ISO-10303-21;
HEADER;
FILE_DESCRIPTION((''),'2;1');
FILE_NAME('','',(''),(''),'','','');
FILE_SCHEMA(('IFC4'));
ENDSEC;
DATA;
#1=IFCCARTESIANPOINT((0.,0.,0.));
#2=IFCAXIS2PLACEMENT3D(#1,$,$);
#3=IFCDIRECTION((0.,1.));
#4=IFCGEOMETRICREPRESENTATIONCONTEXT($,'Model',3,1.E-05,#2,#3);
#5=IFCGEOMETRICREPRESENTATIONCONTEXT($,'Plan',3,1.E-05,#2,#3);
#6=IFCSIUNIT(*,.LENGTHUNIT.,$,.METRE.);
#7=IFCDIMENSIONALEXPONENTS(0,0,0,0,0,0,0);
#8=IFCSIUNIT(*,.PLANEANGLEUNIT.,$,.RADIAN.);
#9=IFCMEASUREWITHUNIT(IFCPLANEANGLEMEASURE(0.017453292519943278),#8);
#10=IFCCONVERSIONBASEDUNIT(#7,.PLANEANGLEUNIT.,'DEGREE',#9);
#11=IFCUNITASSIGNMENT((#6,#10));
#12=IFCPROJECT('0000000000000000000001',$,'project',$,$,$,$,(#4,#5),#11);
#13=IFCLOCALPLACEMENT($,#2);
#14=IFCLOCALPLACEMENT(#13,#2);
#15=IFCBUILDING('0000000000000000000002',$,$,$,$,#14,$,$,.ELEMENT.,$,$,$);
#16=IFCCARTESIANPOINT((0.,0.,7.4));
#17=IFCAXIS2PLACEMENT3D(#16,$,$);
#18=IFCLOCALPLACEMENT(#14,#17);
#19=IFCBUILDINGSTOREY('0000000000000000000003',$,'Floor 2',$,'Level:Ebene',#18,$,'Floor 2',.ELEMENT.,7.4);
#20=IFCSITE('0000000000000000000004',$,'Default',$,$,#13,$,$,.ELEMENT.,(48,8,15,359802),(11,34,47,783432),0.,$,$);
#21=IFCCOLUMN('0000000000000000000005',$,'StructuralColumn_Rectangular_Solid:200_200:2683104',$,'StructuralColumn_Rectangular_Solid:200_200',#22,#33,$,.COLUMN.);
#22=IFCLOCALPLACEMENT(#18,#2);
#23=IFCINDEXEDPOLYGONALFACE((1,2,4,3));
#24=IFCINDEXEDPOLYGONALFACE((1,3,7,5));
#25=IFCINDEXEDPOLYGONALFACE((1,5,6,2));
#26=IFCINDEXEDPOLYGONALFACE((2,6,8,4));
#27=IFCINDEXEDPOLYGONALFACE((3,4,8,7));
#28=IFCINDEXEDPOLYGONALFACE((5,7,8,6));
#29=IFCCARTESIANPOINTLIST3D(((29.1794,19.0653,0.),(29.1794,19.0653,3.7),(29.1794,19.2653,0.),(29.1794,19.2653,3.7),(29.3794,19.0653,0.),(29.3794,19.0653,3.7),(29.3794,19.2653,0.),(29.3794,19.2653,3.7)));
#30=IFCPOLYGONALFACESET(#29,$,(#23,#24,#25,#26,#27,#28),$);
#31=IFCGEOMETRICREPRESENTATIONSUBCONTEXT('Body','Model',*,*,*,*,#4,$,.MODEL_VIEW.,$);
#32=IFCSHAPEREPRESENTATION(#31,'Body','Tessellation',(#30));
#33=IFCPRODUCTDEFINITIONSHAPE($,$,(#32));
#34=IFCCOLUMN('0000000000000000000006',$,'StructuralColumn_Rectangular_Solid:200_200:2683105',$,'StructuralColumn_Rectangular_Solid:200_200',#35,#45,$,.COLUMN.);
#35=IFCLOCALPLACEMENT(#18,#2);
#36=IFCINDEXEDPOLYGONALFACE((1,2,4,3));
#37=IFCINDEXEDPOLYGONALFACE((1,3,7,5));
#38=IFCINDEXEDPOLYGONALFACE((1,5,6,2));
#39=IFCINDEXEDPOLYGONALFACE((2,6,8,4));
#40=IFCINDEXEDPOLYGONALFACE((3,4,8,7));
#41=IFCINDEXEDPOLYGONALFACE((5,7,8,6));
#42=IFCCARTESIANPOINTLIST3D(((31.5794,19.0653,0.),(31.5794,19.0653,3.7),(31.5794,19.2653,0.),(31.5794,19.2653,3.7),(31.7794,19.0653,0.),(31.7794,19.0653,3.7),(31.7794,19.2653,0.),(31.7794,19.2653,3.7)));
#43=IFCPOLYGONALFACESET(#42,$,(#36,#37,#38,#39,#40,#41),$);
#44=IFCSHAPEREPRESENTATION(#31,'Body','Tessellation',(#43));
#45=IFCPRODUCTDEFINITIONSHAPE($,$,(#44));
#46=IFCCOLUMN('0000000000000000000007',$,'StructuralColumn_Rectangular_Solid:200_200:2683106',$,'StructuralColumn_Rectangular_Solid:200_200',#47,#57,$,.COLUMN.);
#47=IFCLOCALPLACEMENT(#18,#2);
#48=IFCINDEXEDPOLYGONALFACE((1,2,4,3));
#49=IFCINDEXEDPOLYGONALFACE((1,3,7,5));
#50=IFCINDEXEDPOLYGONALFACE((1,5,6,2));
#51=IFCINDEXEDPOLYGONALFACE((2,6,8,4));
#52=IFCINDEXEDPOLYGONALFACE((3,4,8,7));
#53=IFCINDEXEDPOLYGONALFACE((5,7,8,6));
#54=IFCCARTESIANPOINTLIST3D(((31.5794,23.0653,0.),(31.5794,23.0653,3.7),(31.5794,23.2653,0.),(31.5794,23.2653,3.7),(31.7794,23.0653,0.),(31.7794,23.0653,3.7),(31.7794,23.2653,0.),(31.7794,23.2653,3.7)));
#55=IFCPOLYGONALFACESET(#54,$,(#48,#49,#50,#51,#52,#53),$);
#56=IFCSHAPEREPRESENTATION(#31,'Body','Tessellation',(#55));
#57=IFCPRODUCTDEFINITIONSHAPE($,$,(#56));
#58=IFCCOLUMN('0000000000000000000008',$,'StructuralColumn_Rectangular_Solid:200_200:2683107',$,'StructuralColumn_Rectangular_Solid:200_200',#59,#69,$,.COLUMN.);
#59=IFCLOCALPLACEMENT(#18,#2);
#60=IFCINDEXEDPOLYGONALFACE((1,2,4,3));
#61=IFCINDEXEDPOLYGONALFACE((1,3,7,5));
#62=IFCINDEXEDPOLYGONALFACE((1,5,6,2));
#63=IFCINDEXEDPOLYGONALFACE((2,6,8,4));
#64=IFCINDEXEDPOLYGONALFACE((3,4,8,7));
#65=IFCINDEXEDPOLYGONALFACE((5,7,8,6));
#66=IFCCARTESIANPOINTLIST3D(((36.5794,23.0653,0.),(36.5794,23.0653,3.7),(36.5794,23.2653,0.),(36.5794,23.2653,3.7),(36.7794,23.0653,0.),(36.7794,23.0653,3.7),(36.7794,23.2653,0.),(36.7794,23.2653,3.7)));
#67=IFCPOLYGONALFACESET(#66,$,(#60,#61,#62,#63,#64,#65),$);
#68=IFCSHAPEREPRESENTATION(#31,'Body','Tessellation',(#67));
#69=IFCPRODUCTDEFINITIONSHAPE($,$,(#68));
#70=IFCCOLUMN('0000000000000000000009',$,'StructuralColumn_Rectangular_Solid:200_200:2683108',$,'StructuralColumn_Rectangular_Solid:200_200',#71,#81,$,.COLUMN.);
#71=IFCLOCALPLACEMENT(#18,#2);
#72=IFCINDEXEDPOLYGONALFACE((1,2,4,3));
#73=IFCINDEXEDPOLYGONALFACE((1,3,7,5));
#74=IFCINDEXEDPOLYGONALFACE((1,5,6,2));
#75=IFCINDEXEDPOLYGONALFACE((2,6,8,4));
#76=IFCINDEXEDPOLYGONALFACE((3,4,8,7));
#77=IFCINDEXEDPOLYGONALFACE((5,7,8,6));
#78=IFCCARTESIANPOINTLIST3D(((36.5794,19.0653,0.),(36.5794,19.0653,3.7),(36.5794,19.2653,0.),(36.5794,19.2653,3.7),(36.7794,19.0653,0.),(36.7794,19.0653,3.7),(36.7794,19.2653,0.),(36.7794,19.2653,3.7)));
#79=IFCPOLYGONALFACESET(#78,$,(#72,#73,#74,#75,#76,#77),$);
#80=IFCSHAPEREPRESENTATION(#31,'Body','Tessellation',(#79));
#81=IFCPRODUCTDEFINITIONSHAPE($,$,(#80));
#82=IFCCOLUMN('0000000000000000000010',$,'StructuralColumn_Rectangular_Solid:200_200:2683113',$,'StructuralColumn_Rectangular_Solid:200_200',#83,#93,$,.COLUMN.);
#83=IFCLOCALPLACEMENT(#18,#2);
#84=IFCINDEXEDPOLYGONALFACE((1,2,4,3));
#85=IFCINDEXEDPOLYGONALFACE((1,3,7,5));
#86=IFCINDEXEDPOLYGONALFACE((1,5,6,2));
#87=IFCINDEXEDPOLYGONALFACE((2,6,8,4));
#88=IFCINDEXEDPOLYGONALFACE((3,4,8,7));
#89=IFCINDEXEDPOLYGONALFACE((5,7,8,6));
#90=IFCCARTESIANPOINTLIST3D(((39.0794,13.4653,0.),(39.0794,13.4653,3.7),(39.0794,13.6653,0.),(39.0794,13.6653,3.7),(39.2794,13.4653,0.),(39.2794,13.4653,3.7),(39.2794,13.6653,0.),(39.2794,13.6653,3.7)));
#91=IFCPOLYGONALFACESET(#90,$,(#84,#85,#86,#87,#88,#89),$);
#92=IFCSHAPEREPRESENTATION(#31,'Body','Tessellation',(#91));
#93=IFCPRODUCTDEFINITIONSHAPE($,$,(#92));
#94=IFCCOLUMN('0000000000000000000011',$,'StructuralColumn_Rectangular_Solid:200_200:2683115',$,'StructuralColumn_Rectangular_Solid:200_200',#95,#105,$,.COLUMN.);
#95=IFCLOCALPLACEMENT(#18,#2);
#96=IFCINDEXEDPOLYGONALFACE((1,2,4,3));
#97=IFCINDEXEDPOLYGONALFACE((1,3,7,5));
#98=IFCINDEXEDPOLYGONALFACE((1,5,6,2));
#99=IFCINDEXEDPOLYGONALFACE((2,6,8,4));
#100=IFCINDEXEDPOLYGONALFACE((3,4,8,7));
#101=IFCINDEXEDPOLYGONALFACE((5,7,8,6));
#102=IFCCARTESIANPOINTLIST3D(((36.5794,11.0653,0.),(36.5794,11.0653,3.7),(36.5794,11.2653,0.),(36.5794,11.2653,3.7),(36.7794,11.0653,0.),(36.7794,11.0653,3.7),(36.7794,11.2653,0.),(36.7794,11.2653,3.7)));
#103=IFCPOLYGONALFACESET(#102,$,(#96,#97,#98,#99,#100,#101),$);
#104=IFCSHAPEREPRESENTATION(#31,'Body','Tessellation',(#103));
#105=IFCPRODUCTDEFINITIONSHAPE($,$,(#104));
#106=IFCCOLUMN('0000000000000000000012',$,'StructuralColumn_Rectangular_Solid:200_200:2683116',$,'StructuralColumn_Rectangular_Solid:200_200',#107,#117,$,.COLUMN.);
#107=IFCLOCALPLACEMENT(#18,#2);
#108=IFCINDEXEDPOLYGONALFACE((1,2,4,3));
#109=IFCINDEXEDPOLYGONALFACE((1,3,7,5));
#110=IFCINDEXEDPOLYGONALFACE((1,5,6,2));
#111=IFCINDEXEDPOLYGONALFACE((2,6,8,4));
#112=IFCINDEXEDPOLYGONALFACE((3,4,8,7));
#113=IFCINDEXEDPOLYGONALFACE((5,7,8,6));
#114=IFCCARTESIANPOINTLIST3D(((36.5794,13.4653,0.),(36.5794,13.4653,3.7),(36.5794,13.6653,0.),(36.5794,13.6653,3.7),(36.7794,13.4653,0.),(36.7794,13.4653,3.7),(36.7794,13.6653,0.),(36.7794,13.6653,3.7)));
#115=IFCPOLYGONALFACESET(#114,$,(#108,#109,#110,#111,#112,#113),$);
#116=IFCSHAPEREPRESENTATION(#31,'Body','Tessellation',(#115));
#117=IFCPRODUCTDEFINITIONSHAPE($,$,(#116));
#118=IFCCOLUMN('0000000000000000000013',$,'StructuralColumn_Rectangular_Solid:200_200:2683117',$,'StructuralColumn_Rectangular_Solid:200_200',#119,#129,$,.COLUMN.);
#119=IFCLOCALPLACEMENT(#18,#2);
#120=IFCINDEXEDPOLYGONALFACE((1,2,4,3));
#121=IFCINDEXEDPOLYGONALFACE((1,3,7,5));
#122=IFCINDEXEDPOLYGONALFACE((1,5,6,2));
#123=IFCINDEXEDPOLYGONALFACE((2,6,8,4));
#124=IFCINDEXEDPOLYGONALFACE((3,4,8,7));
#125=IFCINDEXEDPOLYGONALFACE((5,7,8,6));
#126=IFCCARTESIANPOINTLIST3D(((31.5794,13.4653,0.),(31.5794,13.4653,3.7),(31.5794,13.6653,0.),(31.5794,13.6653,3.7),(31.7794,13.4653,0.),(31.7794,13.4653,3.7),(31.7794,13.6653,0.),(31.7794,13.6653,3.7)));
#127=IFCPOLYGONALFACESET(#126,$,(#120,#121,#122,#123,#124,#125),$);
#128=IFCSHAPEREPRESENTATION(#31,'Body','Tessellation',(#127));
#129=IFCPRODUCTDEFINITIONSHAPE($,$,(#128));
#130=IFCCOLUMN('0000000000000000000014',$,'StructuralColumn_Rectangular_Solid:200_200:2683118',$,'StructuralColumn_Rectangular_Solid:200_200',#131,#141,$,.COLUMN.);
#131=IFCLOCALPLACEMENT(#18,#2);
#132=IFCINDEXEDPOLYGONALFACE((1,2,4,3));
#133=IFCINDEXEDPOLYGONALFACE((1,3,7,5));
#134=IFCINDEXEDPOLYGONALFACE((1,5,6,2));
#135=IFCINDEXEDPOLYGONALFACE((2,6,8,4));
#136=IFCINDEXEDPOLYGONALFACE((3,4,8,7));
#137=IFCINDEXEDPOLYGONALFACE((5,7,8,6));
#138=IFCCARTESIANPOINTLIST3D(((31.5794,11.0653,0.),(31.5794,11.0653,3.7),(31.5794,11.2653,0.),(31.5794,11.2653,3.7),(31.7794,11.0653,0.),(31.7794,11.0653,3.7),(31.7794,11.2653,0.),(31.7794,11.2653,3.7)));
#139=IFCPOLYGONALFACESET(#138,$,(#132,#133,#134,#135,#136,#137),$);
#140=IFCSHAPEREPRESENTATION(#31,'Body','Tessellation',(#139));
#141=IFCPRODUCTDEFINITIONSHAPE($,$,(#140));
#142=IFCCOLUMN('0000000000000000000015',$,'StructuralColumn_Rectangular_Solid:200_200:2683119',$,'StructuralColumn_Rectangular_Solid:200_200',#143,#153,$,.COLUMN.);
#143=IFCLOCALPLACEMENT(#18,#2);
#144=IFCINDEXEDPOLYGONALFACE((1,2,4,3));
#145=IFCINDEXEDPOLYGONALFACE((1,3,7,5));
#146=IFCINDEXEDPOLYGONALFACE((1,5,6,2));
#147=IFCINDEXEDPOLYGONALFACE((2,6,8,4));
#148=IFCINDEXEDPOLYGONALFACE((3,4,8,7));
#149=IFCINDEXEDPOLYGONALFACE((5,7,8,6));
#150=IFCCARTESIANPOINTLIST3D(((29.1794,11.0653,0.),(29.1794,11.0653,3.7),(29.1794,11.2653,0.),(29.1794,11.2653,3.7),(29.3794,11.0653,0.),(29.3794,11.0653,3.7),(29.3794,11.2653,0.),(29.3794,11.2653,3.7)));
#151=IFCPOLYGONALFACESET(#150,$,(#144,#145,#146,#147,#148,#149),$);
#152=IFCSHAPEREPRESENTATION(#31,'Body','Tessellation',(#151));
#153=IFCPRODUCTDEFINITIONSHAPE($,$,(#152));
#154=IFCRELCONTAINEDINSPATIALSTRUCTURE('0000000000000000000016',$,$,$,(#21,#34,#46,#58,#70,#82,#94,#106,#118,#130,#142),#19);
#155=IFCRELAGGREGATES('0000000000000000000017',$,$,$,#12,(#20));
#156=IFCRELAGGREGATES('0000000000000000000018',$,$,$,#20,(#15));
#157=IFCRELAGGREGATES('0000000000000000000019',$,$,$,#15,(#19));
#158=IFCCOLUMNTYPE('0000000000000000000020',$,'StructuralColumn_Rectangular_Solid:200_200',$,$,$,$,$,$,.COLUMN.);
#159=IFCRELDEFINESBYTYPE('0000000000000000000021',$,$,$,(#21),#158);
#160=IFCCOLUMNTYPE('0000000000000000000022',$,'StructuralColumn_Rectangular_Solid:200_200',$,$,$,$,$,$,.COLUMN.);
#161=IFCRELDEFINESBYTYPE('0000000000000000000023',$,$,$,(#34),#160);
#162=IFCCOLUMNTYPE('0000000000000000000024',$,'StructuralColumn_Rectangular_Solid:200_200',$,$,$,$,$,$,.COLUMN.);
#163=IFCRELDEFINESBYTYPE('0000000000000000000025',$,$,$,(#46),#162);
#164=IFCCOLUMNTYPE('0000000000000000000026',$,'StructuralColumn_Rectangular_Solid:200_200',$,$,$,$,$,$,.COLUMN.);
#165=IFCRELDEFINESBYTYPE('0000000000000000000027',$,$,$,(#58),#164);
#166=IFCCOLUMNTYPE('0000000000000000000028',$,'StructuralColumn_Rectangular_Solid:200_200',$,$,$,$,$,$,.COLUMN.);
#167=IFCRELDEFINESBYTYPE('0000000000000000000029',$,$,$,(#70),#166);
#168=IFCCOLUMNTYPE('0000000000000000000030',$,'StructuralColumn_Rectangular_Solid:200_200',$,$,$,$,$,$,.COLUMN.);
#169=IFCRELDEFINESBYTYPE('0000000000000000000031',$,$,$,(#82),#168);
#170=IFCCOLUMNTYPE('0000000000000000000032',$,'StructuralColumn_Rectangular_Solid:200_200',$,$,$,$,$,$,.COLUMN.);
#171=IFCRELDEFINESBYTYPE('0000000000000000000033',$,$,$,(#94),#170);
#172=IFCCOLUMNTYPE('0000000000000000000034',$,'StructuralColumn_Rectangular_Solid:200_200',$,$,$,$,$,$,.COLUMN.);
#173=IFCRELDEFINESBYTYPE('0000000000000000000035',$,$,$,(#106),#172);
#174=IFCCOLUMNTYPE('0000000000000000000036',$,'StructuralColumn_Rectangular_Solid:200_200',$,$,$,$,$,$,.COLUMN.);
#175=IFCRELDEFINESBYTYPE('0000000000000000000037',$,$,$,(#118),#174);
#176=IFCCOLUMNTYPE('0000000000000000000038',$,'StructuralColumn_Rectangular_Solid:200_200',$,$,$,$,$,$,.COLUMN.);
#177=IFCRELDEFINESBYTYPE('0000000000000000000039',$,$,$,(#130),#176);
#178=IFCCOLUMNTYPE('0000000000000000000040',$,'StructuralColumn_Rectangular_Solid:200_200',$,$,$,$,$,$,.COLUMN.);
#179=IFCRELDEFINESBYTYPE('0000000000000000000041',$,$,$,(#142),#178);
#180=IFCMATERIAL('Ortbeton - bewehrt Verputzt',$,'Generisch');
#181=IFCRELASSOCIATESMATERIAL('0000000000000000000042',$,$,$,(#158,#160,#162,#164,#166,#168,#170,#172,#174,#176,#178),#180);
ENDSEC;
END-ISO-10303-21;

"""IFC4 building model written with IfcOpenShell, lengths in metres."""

from ifc_helpers import new_model, entity, si_unit, converted_unit, direction, frame, frame_2d, origin, origin_2d_with_axis, place, context, subcontext, project, spatial, rectangle, extrude, source, transform, mapped, material, material_profile, profile_set, type_object, type_shapes, element, save


model = new_model("IFC4")

# Units and contexts
model_context = context("Model", 3, precision=1e-05, world=origin(), true_north=direction((0.0, 1.0)))
plan_context = context("Plan", 3, precision=1e-05, world=origin(), true_north=direction((0.0, 1.0)))
body_context = subcontext(model_context, "Body", "Model", "MODEL_VIEW")
ifc_project = project(units=[si_unit("LENGTHUNIT", "METRE"), converted_unit("PLANEANGLEUNIT", "DEGREE", entity("IfcPlaneAngleMeasure", 0.017453292519943278), si_unit("PLANEANGLEUNIT", "RADIAN"), dimensions=[0, 0, 0, 0, 0, 0, 0])], contexts=[model_context, plan_context])

# Site, building, storey
site_placement = place(None, origin())
site = spatial("IfcSite", under=ifc_project, at=site_placement, Name="Default", CompositionType="ELEMENT", RefLatitude=(48, 8, 15, 359802), RefLongitude=(11, 34, 47, 783432), RefElevation=0.0)
building_placement = place(site_placement, origin())
building = spatial("IfcBuilding", under=site, at=building_placement, CompositionType="ELEMENT")
storey_placement = place(building_placement, frame((0.0, 0.0, 7.4)))
storey = spatial("IfcBuildingStorey", under=building, at=storey_placement, Name="Floor 2", ObjectType="Level:Ebene", LongName="Floor 2", CompositionType="ELEMENT", Elevation=7.4)

# Columns
ifc_material_1 = material(Name="Ortbeton - bewehrt Verputzt", Category="Generisch")
ifc_material_profile = material_profile(ifc_material_1, rectangle(XDim=0.2, YDim=0.2, at=frame_2d((0.0, 0.0), x_axis=(1.0, 0.0))), Name="200_200")
ifc_profile_set = profile_set([ifc_material_profile], Name="200_200")
column_type_1 = type_object("IfcColumnType", Name="StructuralColumn_Rectangular_Solid:200_200", PredefinedType="COLUMN", material=ifc_profile_set)
shared_shape_1 = source(origin(), body_context, "Body", "SweptSolid", [
    extrude(rectangle(XDim=0.2, YDim=0.2, at=frame_2d((0.0, 0.0), x_axis=(1.0, 0.0))), frame((29.2794, 19.1653, 7.4), z_axis=(0.0, 0.0, 1.0), x_axis=(-1.0, 0.0, 0.0)), (0.0, 0.0, 1.0), 3.7),
])
type_shapes(column_type_1, [shared_shape_1])
column_1_placement = place(storey_placement, frame((0.0, 0.0, -7.4)))
element("IfcColumn", 1, at=column_1_placement, inside=storey, type_object=column_type_1, Name="StructuralColumn_Rectangular_Solid:200_200:2683104", ObjectType="StructuralColumn_Rectangular_Solid:200_200", PredefinedType="COLUMN", context=body_context, shape_type="MappedRepresentation", body=[
    mapped(shared_shape_1, transform((0.0, 0.0, 0.0), scale=1.0)),
])
column_type_2 = type_object("IfcColumnType", Name="StructuralColumn_Rectangular_Solid:200_200", PredefinedType="COLUMN", material=ifc_profile_set)
shared_shape_2 = source(origin(), body_context, "Body", "SweptSolid", [
    extrude(rectangle(XDim=0.2, YDim=0.2, at=frame_2d((0.0, 0.0), x_axis=(1.0, 0.0))), frame((31.6794, 19.1653, 7.4), z_axis=(0.0, 0.0, 1.0), x_axis=(-1.0, 0.0, 0.0)), (0.0, 0.0, 1.0), 3.7),
])
type_shapes(column_type_2, [shared_shape_2])
column_2_placement = place(storey_placement, frame((0.0, 0.0, -7.4)))
element("IfcColumn", 2, at=column_2_placement, inside=storey, type_object=column_type_2, Name="StructuralColumn_Rectangular_Solid:200_200:2683105", ObjectType="StructuralColumn_Rectangular_Solid:200_200", PredefinedType="COLUMN", context=body_context, shape_type="MappedRepresentation", body=[
    mapped(shared_shape_2, transform((0.0, 0.0, 0.0), scale=1.0)),
])
column_type_3 = type_object("IfcColumnType", Name="StructuralColumn_Rectangular_Solid:200_200", PredefinedType="COLUMN", material=ifc_profile_set)
shared_shape_3 = source(origin(), body_context, "Body", "SweptSolid", [
    extrude(rectangle(XDim=0.2, YDim=0.2, at=origin_2d_with_axis()), frame((31.6794, 23.1653, 7.4), z_axis=(0.0, 0.0, 1.0), x_axis=(-1.0, 0.0, 0.0)), (0.0, 0.0, 1.0), 3.7),
])
type_shapes(column_type_3, [shared_shape_3])
column_3_placement = place(storey_placement, frame((0.0, 0.0, -7.4)))
element("IfcColumn", 3, at=column_3_placement, inside=storey, type_object=column_type_3, Name="StructuralColumn_Rectangular_Solid:200_200:2683106", ObjectType="StructuralColumn_Rectangular_Solid:200_200", PredefinedType="COLUMN", context=body_context, shape_type="MappedRepresentation", body=[
    mapped(shared_shape_3, transform((0.0, 0.0, 0.0), scale=1.0)),
])
column_type_4 = type_object("IfcColumnType", Name="StructuralColumn_Rectangular_Solid:200_200", PredefinedType="COLUMN", material=ifc_profile_set)
shared_shape_4 = source(origin(), body_context, "Body", "SweptSolid", [
    extrude(rectangle(XDim=0.2, YDim=0.2, at=origin_2d_with_axis()), frame((36.6794, 23.1653, 7.4), z_axis=(0.0, 0.0, 1.0), x_axis=(-1.0, 0.0, 0.0)), (0.0, 0.0, 1.0), 3.7),
])
type_shapes(column_type_4, [shared_shape_4])
column_4_placement = place(storey_placement, frame((0.0, 0.0, -7.4)))
element("IfcColumn", 4, at=column_4_placement, inside=storey, type_object=column_type_4, Name="StructuralColumn_Rectangular_Solid:200_200:2683107", ObjectType="StructuralColumn_Rectangular_Solid:200_200", PredefinedType="COLUMN", context=body_context, shape_type="MappedRepresentation", body=[
    mapped(shared_shape_4, transform((0.0, 0.0, 0.0), scale=1.0)),
])
column_type_5 = type_object("IfcColumnType", Name="StructuralColumn_Rectangular_Solid:200_200", PredefinedType="COLUMN", material=ifc_profile_set)
shared_shape_5 = source(origin(), body_context, "Body", "SweptSolid", [
    extrude(rectangle(XDim=0.2, YDim=0.2, at=frame_2d((0.0, 0.0), x_axis=(1.0, 0.0))), frame((36.6794, 19.1653, 7.4), z_axis=(0.0, 0.0, 1.0), x_axis=(-1.0, 0.0, 0.0)), (0.0, 0.0, 1.0), 3.7),
])
type_shapes(column_type_5, [shared_shape_5])
column_5_placement = place(storey_placement, frame((0.0, 0.0, -7.4)))
element("IfcColumn", 5, at=column_5_placement, inside=storey, type_object=column_type_5, Name="StructuralColumn_Rectangular_Solid:200_200:2683108", ObjectType="StructuralColumn_Rectangular_Solid:200_200", PredefinedType="COLUMN", context=body_context, shape_type="MappedRepresentation", body=[
    mapped(shared_shape_5, transform((0.0, 0.0, 0.0), scale=1.0)),
])
column_type_6 = type_object("IfcColumnType", Name="StructuralColumn_Rectangular_Solid:200_200", PredefinedType="COLUMN", material=ifc_profile_set)
shared_shape_6 = source(origin(), body_context, "Body", "SweptSolid", [
    extrude(rectangle(XDim=0.2, YDim=0.2, at=frame_2d((0.0, 0.0), x_axis=(1.0, 0.0))), frame((39.1794, 13.5653, 7.4), z_axis=(0.0, 0.0, 1.0), x_axis=(-1.0, 0.0, 0.0)), (0.0, 0.0, 1.0), 3.7),
])
type_shapes(column_type_6, [shared_shape_6])
column_6_placement = place(storey_placement, frame((0.0, 0.0, -7.4)))
element("IfcColumn", 6, at=column_6_placement, inside=storey, type_object=column_type_6, Name="StructuralColumn_Rectangular_Solid:200_200:2683113", ObjectType="StructuralColumn_Rectangular_Solid:200_200", PredefinedType="COLUMN", context=body_context, shape_type="MappedRepresentation", body=[
    mapped(shared_shape_6, transform((0.0, 0.0, 0.0), scale=1.0)),
])
column_type_7 = type_object("IfcColumnType", Name="StructuralColumn_Rectangular_Solid:200_200", PredefinedType="COLUMN", material=ifc_profile_set)
shared_shape_7 = source(origin(), body_context, "Body", "SweptSolid", [
    extrude(rectangle(XDim=0.2, YDim=0.2, at=frame_2d((0.0, 0.0), x_axis=(1.0, 0.0))), frame((36.6794, 11.1653, 7.4), z_axis=(0.0, 0.0, 1.0), x_axis=(-1.0, 0.0, 0.0)), (0.0, 0.0, 1.0), 3.7),
])
type_shapes(column_type_7, [shared_shape_7])
column_7_placement = place(storey_placement, frame((0.0, 0.0, -7.4)))
element("IfcColumn", 7, at=column_7_placement, inside=storey, type_object=column_type_7, Name="StructuralColumn_Rectangular_Solid:200_200:2683115", ObjectType="StructuralColumn_Rectangular_Solid:200_200", PredefinedType="COLUMN", context=body_context, shape_type="MappedRepresentation", body=[
    mapped(shared_shape_7, transform((0.0, 0.0, 0.0), scale=1.0)),
])
column_type_8 = type_object("IfcColumnType", Name="StructuralColumn_Rectangular_Solid:200_200", PredefinedType="COLUMN", material=ifc_profile_set)
shared_shape_8 = source(origin(), body_context, "Body", "SweptSolid", [
    extrude(rectangle(XDim=0.2, YDim=0.2, at=frame_2d((0.0, 0.0), x_axis=(1.0, 0.0))), frame((36.6794, 13.5653, 7.4), z_axis=(0.0, 0.0, 1.0), x_axis=(-1.0, 0.0, 0.0)), (0.0, 0.0, 1.0), 3.7),
])
type_shapes(column_type_8, [shared_shape_8])
column_8_placement = place(storey_placement, frame((0.0, 0.0, -7.4)))
element("IfcColumn", 8, at=column_8_placement, inside=storey, type_object=column_type_8, Name="StructuralColumn_Rectangular_Solid:200_200:2683116", ObjectType="StructuralColumn_Rectangular_Solid:200_200", PredefinedType="COLUMN", context=body_context, shape_type="MappedRepresentation", body=[
    mapped(shared_shape_8, transform((0.0, 0.0, 0.0), scale=1.0)),
])
column_type_9 = type_object("IfcColumnType", Name="StructuralColumn_Rectangular_Solid:200_200", PredefinedType="COLUMN", material=ifc_profile_set)
shared_shape_9 = source(origin(), body_context, "Body", "SweptSolid", [
    extrude(rectangle(XDim=0.2, YDim=0.2, at=frame_2d((0.0, 0.0), x_axis=(1.0, 0.0))), frame((31.6794, 13.5653, 7.4), z_axis=(0.0, 0.0, 1.0), x_axis=(-1.0, 0.0, 0.0)), (0.0, 0.0, 1.0), 3.7),
])
type_shapes(column_type_9, [shared_shape_9])
column_9_placement = place(storey_placement, frame((0.0, 0.0, -7.4)))
element("IfcColumn", 9, at=column_9_placement, inside=storey, type_object=column_type_9, Name="StructuralColumn_Rectangular_Solid:200_200:2683117", ObjectType="StructuralColumn_Rectangular_Solid:200_200", PredefinedType="COLUMN", context=body_context, shape_type="MappedRepresentation", body=[
    mapped(shared_shape_9, transform((0.0, 0.0, 0.0), scale=1.0)),
])
column_type_10 = type_object("IfcColumnType", Name="StructuralColumn_Rectangular_Solid:200_200", PredefinedType="COLUMN", material=ifc_profile_set)
shared_shape_10 = source(origin(), body_context, "Body", "SweptSolid", [
    extrude(rectangle(XDim=0.2, YDim=0.2, at=frame_2d((0.0, 0.0), x_axis=(1.0, 0.0))), frame((31.6794, 11.1653, 7.4), z_axis=(0.0, 0.0, 1.0), x_axis=(-1.0, 0.0, 0.0)), (0.0, 0.0, 1.0), 3.7),
])
type_shapes(column_type_10, [shared_shape_10])
column_10_placement = place(storey_placement, frame((0.0, 0.0, -7.4)))
element("IfcColumn", 10, at=column_10_placement, inside=storey, type_object=column_type_10, Name="StructuralColumn_Rectangular_Solid:200_200:2683118", ObjectType="StructuralColumn_Rectangular_Solid:200_200", PredefinedType="COLUMN", context=body_context, shape_type="MappedRepresentation", body=[
    mapped(shared_shape_10, transform((0.0, 0.0, 0.0), scale=1.0)),
])
column_type_11 = type_object("IfcColumnType", Name="StructuralColumn_Rectangular_Solid:200_200", PredefinedType="COLUMN", material=ifc_profile_set)
shared_shape_11 = source(origin(), body_context, "Body", "SweptSolid", [
    extrude(rectangle(XDim=0.2, YDim=0.2, at=frame_2d((0.0, 0.0), x_axis=(1.0, 0.0))), frame((29.2794, 11.1653, 7.4), z_axis=(0.0, 0.0, 1.0), x_axis=(-1.0, 0.0, 0.0)), (0.0, 0.0, 1.0), 3.7),
])
type_shapes(column_type_11, [shared_shape_11])
column_11_placement = place(storey_placement, frame((0.0, 0.0, -7.4)))
element("IfcColumn", 11, at=column_11_placement, inside=storey, type_object=column_type_11, Name="StructuralColumn_Rectangular_Solid:200_200:2683119", ObjectType="StructuralColumn_Rectangular_Solid:200_200", PredefinedType="COLUMN", context=body_context, shape_type="MappedRepresentation", body=[
    mapped(shared_shape_11, transform((0.0, 0.0, 0.0), scale=1.0)),
])

save(model, "model.ifc")
